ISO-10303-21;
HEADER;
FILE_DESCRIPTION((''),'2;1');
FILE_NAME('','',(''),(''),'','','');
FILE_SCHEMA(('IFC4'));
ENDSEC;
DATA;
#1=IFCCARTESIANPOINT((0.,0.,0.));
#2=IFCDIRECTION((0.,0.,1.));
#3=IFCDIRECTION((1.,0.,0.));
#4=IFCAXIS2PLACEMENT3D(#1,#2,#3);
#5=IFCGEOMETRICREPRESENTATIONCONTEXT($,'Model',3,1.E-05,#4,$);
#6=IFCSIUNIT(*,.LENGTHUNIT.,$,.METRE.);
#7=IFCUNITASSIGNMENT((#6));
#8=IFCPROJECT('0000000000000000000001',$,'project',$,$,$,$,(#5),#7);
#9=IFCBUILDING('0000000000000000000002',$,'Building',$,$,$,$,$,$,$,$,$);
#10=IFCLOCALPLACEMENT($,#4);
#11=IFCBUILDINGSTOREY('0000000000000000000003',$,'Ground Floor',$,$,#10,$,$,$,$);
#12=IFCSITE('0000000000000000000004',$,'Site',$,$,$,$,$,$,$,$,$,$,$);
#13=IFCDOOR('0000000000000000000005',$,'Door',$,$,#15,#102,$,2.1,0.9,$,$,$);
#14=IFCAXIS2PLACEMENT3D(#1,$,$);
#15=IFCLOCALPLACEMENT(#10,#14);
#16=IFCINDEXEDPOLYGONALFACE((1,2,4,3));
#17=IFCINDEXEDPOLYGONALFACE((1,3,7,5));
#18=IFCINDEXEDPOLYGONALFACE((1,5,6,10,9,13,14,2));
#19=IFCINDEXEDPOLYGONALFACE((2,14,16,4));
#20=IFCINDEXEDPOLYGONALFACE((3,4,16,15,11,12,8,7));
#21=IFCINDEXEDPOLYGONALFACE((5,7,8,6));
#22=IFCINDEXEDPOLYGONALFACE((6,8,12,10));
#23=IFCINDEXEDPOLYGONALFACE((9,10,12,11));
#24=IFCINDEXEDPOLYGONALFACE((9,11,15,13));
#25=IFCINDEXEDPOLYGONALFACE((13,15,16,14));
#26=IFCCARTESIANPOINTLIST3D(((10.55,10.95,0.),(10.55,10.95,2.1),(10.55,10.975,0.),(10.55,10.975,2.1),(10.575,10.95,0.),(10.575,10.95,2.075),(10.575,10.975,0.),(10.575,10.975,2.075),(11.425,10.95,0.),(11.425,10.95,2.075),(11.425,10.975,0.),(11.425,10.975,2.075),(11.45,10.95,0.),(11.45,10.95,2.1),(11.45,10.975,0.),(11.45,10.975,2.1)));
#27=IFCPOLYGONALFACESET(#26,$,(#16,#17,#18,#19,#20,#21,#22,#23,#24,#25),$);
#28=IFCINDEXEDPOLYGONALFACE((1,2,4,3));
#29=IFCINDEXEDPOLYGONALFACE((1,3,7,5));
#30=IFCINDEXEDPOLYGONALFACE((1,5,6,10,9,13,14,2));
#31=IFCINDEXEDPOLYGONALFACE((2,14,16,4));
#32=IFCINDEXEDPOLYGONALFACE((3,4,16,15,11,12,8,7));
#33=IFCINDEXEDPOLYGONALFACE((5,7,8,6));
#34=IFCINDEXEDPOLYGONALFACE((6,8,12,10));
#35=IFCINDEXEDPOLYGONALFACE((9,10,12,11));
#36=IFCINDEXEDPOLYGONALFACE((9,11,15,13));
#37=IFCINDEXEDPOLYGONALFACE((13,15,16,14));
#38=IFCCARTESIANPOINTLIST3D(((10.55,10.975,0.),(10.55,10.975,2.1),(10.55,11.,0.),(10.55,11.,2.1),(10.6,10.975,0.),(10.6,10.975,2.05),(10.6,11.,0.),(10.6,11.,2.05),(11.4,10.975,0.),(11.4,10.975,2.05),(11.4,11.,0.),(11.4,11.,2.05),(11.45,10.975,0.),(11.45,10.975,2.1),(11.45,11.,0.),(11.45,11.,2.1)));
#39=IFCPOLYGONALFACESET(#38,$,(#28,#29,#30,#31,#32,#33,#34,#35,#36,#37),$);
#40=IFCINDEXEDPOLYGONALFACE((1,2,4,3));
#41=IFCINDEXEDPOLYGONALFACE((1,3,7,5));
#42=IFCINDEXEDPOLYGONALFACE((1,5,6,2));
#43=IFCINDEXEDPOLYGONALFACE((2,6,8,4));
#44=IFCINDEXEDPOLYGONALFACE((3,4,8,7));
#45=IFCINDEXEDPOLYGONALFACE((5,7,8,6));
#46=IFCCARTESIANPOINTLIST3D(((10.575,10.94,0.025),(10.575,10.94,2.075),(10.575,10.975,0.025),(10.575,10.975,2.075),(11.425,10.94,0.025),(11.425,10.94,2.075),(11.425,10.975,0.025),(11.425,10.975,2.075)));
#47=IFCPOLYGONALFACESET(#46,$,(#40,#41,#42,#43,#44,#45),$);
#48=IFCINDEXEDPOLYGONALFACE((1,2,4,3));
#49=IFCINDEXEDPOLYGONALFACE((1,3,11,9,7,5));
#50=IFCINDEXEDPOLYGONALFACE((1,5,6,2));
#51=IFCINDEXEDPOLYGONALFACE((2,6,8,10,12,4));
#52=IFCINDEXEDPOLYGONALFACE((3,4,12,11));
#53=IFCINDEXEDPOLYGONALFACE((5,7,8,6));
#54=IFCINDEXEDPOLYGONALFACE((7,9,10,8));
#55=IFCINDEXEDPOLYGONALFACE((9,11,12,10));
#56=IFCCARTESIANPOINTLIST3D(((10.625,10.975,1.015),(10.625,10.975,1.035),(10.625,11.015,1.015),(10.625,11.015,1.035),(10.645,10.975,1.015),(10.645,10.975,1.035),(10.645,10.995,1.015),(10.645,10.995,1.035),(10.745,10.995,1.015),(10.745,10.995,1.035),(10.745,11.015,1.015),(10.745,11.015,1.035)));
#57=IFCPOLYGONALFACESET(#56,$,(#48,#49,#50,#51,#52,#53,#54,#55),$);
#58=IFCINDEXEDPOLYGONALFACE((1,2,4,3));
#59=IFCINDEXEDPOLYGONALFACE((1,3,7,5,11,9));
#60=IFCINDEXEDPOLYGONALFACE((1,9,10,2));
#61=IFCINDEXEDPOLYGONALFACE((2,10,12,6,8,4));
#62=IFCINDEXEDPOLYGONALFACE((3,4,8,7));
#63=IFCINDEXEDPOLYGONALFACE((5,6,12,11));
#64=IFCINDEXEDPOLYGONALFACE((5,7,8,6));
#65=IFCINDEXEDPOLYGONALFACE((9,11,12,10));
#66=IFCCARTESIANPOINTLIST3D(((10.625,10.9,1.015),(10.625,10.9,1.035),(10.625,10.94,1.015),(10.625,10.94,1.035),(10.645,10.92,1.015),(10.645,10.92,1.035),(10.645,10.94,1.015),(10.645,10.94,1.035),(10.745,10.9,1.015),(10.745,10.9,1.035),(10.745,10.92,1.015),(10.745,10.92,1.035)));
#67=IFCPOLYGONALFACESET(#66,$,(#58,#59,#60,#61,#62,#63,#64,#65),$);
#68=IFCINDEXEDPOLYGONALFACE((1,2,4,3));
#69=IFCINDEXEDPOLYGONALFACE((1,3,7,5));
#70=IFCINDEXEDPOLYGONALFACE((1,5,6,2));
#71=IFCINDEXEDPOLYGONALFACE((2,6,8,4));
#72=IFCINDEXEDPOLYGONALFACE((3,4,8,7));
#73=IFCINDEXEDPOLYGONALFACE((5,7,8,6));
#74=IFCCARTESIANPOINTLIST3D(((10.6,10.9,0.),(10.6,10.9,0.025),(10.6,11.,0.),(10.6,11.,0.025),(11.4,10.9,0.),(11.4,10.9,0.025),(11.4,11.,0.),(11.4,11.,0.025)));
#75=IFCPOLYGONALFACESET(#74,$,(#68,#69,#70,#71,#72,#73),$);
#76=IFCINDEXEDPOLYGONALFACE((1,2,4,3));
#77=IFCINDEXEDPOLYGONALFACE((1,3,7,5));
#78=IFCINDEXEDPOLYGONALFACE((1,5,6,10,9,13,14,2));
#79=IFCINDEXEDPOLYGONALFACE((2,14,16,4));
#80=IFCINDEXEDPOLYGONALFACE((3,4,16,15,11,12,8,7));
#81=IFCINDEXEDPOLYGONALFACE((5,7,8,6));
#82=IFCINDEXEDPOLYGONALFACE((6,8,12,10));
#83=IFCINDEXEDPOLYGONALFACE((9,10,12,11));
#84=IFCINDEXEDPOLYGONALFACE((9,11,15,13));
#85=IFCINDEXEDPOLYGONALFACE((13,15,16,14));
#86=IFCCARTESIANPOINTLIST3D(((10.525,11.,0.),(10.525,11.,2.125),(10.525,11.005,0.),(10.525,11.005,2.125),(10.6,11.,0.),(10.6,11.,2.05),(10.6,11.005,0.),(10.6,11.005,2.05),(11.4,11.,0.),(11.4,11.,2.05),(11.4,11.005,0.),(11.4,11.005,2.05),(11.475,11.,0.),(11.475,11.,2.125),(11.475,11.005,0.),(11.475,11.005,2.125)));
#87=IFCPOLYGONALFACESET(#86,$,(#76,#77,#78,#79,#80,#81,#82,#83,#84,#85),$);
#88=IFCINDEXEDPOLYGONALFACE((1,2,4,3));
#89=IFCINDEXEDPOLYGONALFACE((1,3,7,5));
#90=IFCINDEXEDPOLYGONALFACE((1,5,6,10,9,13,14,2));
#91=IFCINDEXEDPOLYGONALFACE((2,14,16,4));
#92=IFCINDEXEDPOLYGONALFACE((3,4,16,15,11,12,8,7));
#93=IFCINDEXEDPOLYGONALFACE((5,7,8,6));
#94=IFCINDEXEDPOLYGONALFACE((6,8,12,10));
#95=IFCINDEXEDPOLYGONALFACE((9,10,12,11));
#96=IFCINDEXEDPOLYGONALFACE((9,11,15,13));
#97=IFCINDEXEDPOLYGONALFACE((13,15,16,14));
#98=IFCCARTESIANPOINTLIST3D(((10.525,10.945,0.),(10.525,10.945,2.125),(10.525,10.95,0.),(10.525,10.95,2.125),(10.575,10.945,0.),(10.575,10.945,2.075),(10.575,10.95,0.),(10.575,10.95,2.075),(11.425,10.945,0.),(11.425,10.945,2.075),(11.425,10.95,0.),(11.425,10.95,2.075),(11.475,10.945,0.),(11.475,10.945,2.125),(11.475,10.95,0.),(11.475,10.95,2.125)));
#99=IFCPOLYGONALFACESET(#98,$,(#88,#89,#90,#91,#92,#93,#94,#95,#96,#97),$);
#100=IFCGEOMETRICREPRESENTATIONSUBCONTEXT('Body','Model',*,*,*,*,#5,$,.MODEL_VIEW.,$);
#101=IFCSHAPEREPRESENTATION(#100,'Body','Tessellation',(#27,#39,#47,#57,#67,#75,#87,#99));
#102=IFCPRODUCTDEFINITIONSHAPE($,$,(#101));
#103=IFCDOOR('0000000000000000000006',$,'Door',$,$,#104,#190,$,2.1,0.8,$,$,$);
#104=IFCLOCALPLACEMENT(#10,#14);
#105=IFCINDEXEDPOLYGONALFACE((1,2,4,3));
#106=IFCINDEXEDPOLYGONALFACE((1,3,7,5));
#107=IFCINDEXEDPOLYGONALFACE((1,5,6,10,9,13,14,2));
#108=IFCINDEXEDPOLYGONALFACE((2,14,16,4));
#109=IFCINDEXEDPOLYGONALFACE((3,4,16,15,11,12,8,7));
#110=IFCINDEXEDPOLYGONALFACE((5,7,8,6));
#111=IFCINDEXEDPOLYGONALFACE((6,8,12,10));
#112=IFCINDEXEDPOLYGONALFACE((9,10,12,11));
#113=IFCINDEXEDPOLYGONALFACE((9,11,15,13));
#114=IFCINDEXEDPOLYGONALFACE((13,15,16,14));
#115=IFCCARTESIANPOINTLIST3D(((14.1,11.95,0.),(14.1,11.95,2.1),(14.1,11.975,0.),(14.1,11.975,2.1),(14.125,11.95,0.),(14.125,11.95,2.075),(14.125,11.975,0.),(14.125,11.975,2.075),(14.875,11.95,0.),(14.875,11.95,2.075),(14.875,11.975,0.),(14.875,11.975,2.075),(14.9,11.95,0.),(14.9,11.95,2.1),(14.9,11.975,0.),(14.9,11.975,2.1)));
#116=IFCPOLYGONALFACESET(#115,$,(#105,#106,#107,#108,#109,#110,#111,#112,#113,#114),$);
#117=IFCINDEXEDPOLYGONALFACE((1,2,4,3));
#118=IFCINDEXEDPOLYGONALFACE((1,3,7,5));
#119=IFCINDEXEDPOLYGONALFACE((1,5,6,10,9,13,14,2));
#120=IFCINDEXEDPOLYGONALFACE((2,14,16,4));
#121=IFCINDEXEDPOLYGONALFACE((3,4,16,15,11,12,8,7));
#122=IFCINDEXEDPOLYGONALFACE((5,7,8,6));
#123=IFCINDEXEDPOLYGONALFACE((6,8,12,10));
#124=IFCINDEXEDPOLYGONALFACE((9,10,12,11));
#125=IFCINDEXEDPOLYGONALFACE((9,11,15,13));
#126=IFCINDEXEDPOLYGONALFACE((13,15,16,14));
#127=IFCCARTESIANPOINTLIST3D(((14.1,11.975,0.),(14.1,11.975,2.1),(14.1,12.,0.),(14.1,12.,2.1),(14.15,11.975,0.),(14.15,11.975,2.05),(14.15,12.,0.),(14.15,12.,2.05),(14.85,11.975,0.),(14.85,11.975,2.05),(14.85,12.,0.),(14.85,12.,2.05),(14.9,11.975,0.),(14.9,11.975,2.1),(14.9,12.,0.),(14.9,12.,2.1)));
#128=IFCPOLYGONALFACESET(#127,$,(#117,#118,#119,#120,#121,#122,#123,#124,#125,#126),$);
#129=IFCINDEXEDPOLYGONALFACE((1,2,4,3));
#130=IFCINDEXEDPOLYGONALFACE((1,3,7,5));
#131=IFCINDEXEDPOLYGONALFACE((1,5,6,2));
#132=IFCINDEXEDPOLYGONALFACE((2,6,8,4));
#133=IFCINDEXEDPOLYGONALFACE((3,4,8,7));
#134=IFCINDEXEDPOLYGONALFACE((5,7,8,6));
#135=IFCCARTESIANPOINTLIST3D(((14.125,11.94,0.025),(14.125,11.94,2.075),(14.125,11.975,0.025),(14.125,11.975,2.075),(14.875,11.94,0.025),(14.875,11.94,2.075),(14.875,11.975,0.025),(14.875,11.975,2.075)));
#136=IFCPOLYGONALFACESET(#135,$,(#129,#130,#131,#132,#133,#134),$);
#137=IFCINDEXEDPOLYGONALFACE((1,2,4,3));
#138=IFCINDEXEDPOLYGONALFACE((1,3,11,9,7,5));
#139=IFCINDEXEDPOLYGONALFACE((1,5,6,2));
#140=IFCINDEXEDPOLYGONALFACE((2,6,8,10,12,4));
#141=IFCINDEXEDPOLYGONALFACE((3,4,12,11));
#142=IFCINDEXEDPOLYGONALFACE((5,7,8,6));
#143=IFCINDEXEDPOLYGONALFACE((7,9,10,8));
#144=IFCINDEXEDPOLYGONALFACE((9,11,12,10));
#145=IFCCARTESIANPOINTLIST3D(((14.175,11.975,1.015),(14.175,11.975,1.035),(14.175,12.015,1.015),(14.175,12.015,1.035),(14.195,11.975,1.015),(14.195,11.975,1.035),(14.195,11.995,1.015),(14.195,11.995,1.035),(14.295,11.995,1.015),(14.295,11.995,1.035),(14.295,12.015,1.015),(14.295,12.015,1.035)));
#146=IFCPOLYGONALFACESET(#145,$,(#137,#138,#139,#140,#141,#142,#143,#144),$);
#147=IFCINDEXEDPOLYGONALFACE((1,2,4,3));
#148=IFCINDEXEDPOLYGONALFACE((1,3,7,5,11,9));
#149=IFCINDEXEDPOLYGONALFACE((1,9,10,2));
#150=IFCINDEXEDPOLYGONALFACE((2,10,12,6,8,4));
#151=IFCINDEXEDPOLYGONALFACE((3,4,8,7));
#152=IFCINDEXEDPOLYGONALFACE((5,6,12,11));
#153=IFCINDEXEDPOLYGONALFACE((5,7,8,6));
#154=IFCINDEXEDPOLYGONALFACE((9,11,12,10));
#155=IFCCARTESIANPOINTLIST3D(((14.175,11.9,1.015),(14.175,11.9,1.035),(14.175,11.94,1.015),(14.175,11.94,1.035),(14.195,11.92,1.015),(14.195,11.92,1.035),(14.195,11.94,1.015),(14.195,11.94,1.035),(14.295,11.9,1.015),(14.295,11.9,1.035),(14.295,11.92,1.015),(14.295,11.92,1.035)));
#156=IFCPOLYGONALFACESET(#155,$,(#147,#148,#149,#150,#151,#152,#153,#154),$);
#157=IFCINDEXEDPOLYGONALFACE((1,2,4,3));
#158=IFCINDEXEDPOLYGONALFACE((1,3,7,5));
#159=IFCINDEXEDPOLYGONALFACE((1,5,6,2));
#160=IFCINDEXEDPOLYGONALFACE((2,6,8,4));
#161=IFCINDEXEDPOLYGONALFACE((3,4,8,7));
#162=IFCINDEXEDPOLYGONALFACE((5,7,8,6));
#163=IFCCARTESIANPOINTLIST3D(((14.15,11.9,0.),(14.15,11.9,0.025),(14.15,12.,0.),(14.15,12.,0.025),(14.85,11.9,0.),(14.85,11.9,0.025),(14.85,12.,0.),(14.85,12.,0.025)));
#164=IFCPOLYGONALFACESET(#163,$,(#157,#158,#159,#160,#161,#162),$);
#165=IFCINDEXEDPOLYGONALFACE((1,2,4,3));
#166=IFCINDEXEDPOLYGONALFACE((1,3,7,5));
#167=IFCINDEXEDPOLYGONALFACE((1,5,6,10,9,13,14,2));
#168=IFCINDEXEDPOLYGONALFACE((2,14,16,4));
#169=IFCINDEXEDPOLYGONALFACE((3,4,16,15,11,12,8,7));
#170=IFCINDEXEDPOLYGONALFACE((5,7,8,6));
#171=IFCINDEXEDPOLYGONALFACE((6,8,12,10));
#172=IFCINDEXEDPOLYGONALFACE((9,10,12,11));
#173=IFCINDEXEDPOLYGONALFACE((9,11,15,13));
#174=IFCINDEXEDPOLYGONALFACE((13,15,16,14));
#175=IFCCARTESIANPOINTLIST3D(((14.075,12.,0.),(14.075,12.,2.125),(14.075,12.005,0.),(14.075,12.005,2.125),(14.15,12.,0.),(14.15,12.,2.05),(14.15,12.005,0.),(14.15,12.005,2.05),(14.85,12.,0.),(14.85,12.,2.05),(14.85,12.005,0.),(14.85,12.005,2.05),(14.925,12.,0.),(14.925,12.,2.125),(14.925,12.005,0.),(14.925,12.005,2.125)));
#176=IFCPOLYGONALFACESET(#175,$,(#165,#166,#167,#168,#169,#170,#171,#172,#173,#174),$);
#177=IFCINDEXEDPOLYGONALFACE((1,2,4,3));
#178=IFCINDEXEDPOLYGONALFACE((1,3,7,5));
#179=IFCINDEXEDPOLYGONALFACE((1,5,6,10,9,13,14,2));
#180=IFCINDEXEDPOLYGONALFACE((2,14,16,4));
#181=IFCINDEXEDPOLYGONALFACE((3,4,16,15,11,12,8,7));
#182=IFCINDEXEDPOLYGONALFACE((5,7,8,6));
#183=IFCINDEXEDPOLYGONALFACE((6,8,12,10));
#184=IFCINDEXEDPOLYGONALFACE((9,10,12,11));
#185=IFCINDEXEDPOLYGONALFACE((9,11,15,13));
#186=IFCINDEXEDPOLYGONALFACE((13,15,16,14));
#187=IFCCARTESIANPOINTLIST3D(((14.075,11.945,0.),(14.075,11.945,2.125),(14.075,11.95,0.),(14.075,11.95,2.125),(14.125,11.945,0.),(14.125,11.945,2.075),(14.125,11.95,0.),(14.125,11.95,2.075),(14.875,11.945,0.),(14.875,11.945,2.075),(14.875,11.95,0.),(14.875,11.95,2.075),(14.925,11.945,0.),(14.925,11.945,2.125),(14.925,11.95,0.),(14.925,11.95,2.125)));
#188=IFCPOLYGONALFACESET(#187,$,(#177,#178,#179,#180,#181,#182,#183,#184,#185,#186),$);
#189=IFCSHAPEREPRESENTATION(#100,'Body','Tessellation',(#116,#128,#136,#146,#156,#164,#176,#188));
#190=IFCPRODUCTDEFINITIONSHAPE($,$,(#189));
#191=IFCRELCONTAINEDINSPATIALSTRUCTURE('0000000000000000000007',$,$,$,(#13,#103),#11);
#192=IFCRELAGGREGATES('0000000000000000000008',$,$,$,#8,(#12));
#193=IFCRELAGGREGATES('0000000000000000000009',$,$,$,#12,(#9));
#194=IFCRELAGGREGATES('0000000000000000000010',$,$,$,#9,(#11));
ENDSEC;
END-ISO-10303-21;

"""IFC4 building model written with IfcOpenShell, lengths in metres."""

from ifc_helpers import new_model, si_unit, frame, origin_with_axes, place, context, subcontext, project, spatial, line, indexed_curve, outline, extrude, element, save


model = new_model("IFC4")

# Units and contexts
model_context = context("Model", 3, precision=1e-05, world=origin_with_axes())
body_context = subcontext(model_context, "Body", "Model", "MODEL_VIEW")
ifc_project = project(units=[si_unit("LENGTHUNIT", "METRE")], contexts=[model_context])

# Site, building, storey
site = spatial("IfcSite", under=ifc_project, Name="Site")
building = spatial("IfcBuilding", under=site, Name="Building")
storey_placement = place(None, origin_with_axes())
storey = spatial("IfcBuildingStorey", under=building, at=storey_placement, Name="Ground Floor")

# Doors
door_1_placement = place(storey_placement, frame((11.45, 11.0, 0.0), z_axis=(0.0, 0.0, 1.0), x_axis=(-1.0, 0.0, 0.0)))
element("IfcDoor", 1, at=door_1_placement, inside=storey, Name="Door", OverallHeight=2.1, OverallWidth=0.9, context=body_context, shape_type="SweptSolid", body=[
    extrude(outline(indexed_curve([(0.0, 0.0), (0.0, 2.1), (0.9, 2.1), (0.9, 0.0), (0.875, 0.0), (0.875, 2.075), (0.025, 2.075), (0.025, 0.0)], segments=[line(1, 2, 3, 4, 5, 6, 7, 8, 1)])), frame((0.0, 0.025, 0.0), z_axis=(0.0, -1.0, 0.0), x_axis=(1.0, 0.0, 0.0)), (0.0, 0.0, -1.0), 0.025),
    extrude(outline(indexed_curve([(0.0, 0.0), (0.0, 2.1), (0.9, 2.1), (0.9, 0.0), (0.85, 0.0), (0.85, 2.05), (0.05, 2.05), (0.05, 0.0)], segments=[line(1, 2, 3, 4, 5, 6, 7, 8, 1)])), frame((0.0, 0.0, 0.0), z_axis=(0.0, -1.0, 0.0), x_axis=(1.0, 0.0, 0.0)), (0.0, 0.0, -1.0), 0.025),
    extrude(outline(indexed_curve([(0.0, 0.0), (0.85, 0.0), (0.85, 0.035), (0.0, 0.035)], segments=[line(1, 2, 3, 4, 1)])), frame((0.025, 0.025, 0.025), z_axis=(0.0, 0.0, 1.0), x_axis=(1.0, 0.0, 0.0)), (0.0, 0.0, 1.0), 2.05),
    extrude(outline(indexed_curve([(0.0, 0.0), (0.0, -0.04), (-0.12, -0.04), (-0.12, -0.02), (-0.02, -0.02), (-0.02, 0.0)], segments=[line(1, 2, 3, 4, 5, 6, 1)])), frame((0.825, 0.025, 1.015), z_axis=(0.0, 0.0, 1.0), x_axis=(1.0, 0.0, 0.0)), (0.0, 0.0, 1.0), 0.02),
    extrude(outline(indexed_curve([(0.0, 0.0), (0.0, 0.04), (-0.12, 0.04), (-0.12, 0.02), (-0.02, 0.02), (-0.02, 0.0)], segments=[line(1, 2, 3, 4, 5, 6, 1)])), frame((0.825, 0.06, 1.015), z_axis=(0.0, 0.0, 1.0), x_axis=(1.0, 0.0, 0.0)), (0.0, 0.0, 1.0), 0.02),
    extrude(outline(indexed_curve([(0.0, 0.0), (0.8, 0.0), (0.8, 0.1), (0.0, 0.1)], segments=[line(1, 2, 3, 4, 1)])), frame((0.05, 0.0, 0.0), z_axis=(0.0, 0.0, 1.0), x_axis=(1.0, 0.0, 0.0)), (0.0, 0.0, 1.0), 0.025),
    extrude(outline(indexed_curve([(0.0, 0.0), (0.0, 2.125), (0.95, 2.125), (0.95, 0.0), (0.875, 0.0), (0.875, 2.05), (0.075, 2.05), (0.075, 0.0)], segments=[line(1, 2, 3, 4, 5, 6, 7, 8, 1)])), frame((-0.025, -0.005, 0.0), z_axis=(0.0, -1.0, 0.0), x_axis=(1.0, 0.0, 0.0)), (0.0, 0.0, -1.0), 0.005),
    extrude(outline(indexed_curve([(0.0, 0.0), (0.0, 2.125), (0.95, 2.125), (0.95, 0.0), (0.9, 0.0), (0.9, 2.075), (0.05, 2.075), (0.05, 0.0)], segments=[line(1, 2, 3, 4, 5, 6, 7, 8, 1)])), frame((-0.025, 0.05, 0.0), z_axis=(0.0, -1.0, 0.0), x_axis=(1.0, 0.0, 0.0)), (0.0, 0.0, -1.0), 0.005),
])
door_2_placement = place(storey_placement, frame((14.9, 12.0, 0.0), z_axis=(0.0, 0.0, 1.0), x_axis=(-1.0, 0.0, 0.0)))
element("IfcDoor", 2, at=door_2_placement, inside=storey, Name="Door", OverallHeight=2.1, OverallWidth=0.8, context=body_context, shape_type="SweptSolid", body=[
    extrude(outline(indexed_curve([(0.0, 0.0), (0.0, 2.1), (0.8, 2.1), (0.8, 0.0), (0.775, 0.0), (0.775, 2.075), (0.025, 2.075), (0.025, 0.0)], segments=[line(1, 2, 3, 4, 5, 6, 7, 8, 1)])), frame((0.0, 0.025, 0.0), z_axis=(0.0, -1.0, 0.0), x_axis=(1.0, 0.0, 0.0)), (0.0, 0.0, -1.0), 0.025),
    extrude(outline(indexed_curve([(0.0, 0.0), (0.0, 2.1), (0.8, 2.1), (0.8, 0.0), (0.75, 0.0), (0.75, 2.05), (0.05, 2.05), (0.05, 0.0)], segments=[line(1, 2, 3, 4, 5, 6, 7, 8, 1)])), frame((0.0, 0.0, 0.0), z_axis=(0.0, -1.0, 0.0), x_axis=(1.0, 0.0, 0.0)), (0.0, 0.0, -1.0), 0.025),
    extrude(outline(indexed_curve([(0.0, 0.0), (0.75, 0.0), (0.75, 0.035), (0.0, 0.035)], segments=[line(1, 2, 3, 4, 1)])), frame((0.025, 0.025, 0.025), z_axis=(0.0, 0.0, 1.0), x_axis=(1.0, 0.0, 0.0)), (0.0, 0.0, 1.0), 2.05),
    extrude(outline(indexed_curve([(0.0, 0.0), (0.0, -0.04), (-0.12, -0.04), (-0.12, -0.02), (-0.02, -0.02), (-0.02, 0.0)], segments=[line(1, 2, 3, 4, 5, 6, 1)])), frame((0.725, 0.025, 1.015), z_axis=(0.0, 0.0, 1.0), x_axis=(1.0, 0.0, 0.0)), (0.0, 0.0, 1.0), 0.02),
    extrude(outline(indexed_curve([(0.0, 0.0), (0.0, 0.04), (-0.12, 0.04), (-0.12, 0.02), (-0.02, 0.02), (-0.02, 0.0)], segments=[line(1, 2, 3, 4, 5, 6, 1)])), frame((0.725, 0.06, 1.015), z_axis=(0.0, 0.0, 1.0), x_axis=(1.0, 0.0, 0.0)), (0.0, 0.0, 1.0), 0.02),
    extrude(outline(indexed_curve([(0.0, 0.0), (0.7, 0.0), (0.7, 0.1), (0.0, 0.1)], segments=[line(1, 2, 3, 4, 1)])), frame((0.05, 0.0, 0.0), z_axis=(0.0, 0.0, 1.0), x_axis=(1.0, 0.0, 0.0)), (0.0, 0.0, 1.0), 0.025),
    extrude(outline(indexed_curve([(0.0, 0.0), (0.0, 2.125), (0.85, 2.125), (0.85, 0.0), (0.775, 0.0), (0.775, 2.05), (0.075, 2.05), (0.075, 0.0)], segments=[line(1, 2, 3, 4, 5, 6, 7, 8, 1)])), frame((-0.025, -0.005, 0.0), z_axis=(0.0, -1.0, 0.0), x_axis=(1.0, 0.0, 0.0)), (0.0, 0.0, -1.0), 0.005),
    extrude(outline(indexed_curve([(0.0, 0.0), (0.0, 2.125), (0.85, 2.125), (0.85, 0.0), (0.8, 0.0), (0.8, 2.075), (0.05, 2.075), (0.05, 0.0)], segments=[line(1, 2, 3, 4, 5, 6, 7, 8, 1)])), frame((-0.025, 0.05, 0.0), z_axis=(0.0, -1.0, 0.0), x_axis=(1.0, 0.0, 0.0)), (0.0, 0.0, -1.0), 0.005),
])

save(model, "model.ifc")
